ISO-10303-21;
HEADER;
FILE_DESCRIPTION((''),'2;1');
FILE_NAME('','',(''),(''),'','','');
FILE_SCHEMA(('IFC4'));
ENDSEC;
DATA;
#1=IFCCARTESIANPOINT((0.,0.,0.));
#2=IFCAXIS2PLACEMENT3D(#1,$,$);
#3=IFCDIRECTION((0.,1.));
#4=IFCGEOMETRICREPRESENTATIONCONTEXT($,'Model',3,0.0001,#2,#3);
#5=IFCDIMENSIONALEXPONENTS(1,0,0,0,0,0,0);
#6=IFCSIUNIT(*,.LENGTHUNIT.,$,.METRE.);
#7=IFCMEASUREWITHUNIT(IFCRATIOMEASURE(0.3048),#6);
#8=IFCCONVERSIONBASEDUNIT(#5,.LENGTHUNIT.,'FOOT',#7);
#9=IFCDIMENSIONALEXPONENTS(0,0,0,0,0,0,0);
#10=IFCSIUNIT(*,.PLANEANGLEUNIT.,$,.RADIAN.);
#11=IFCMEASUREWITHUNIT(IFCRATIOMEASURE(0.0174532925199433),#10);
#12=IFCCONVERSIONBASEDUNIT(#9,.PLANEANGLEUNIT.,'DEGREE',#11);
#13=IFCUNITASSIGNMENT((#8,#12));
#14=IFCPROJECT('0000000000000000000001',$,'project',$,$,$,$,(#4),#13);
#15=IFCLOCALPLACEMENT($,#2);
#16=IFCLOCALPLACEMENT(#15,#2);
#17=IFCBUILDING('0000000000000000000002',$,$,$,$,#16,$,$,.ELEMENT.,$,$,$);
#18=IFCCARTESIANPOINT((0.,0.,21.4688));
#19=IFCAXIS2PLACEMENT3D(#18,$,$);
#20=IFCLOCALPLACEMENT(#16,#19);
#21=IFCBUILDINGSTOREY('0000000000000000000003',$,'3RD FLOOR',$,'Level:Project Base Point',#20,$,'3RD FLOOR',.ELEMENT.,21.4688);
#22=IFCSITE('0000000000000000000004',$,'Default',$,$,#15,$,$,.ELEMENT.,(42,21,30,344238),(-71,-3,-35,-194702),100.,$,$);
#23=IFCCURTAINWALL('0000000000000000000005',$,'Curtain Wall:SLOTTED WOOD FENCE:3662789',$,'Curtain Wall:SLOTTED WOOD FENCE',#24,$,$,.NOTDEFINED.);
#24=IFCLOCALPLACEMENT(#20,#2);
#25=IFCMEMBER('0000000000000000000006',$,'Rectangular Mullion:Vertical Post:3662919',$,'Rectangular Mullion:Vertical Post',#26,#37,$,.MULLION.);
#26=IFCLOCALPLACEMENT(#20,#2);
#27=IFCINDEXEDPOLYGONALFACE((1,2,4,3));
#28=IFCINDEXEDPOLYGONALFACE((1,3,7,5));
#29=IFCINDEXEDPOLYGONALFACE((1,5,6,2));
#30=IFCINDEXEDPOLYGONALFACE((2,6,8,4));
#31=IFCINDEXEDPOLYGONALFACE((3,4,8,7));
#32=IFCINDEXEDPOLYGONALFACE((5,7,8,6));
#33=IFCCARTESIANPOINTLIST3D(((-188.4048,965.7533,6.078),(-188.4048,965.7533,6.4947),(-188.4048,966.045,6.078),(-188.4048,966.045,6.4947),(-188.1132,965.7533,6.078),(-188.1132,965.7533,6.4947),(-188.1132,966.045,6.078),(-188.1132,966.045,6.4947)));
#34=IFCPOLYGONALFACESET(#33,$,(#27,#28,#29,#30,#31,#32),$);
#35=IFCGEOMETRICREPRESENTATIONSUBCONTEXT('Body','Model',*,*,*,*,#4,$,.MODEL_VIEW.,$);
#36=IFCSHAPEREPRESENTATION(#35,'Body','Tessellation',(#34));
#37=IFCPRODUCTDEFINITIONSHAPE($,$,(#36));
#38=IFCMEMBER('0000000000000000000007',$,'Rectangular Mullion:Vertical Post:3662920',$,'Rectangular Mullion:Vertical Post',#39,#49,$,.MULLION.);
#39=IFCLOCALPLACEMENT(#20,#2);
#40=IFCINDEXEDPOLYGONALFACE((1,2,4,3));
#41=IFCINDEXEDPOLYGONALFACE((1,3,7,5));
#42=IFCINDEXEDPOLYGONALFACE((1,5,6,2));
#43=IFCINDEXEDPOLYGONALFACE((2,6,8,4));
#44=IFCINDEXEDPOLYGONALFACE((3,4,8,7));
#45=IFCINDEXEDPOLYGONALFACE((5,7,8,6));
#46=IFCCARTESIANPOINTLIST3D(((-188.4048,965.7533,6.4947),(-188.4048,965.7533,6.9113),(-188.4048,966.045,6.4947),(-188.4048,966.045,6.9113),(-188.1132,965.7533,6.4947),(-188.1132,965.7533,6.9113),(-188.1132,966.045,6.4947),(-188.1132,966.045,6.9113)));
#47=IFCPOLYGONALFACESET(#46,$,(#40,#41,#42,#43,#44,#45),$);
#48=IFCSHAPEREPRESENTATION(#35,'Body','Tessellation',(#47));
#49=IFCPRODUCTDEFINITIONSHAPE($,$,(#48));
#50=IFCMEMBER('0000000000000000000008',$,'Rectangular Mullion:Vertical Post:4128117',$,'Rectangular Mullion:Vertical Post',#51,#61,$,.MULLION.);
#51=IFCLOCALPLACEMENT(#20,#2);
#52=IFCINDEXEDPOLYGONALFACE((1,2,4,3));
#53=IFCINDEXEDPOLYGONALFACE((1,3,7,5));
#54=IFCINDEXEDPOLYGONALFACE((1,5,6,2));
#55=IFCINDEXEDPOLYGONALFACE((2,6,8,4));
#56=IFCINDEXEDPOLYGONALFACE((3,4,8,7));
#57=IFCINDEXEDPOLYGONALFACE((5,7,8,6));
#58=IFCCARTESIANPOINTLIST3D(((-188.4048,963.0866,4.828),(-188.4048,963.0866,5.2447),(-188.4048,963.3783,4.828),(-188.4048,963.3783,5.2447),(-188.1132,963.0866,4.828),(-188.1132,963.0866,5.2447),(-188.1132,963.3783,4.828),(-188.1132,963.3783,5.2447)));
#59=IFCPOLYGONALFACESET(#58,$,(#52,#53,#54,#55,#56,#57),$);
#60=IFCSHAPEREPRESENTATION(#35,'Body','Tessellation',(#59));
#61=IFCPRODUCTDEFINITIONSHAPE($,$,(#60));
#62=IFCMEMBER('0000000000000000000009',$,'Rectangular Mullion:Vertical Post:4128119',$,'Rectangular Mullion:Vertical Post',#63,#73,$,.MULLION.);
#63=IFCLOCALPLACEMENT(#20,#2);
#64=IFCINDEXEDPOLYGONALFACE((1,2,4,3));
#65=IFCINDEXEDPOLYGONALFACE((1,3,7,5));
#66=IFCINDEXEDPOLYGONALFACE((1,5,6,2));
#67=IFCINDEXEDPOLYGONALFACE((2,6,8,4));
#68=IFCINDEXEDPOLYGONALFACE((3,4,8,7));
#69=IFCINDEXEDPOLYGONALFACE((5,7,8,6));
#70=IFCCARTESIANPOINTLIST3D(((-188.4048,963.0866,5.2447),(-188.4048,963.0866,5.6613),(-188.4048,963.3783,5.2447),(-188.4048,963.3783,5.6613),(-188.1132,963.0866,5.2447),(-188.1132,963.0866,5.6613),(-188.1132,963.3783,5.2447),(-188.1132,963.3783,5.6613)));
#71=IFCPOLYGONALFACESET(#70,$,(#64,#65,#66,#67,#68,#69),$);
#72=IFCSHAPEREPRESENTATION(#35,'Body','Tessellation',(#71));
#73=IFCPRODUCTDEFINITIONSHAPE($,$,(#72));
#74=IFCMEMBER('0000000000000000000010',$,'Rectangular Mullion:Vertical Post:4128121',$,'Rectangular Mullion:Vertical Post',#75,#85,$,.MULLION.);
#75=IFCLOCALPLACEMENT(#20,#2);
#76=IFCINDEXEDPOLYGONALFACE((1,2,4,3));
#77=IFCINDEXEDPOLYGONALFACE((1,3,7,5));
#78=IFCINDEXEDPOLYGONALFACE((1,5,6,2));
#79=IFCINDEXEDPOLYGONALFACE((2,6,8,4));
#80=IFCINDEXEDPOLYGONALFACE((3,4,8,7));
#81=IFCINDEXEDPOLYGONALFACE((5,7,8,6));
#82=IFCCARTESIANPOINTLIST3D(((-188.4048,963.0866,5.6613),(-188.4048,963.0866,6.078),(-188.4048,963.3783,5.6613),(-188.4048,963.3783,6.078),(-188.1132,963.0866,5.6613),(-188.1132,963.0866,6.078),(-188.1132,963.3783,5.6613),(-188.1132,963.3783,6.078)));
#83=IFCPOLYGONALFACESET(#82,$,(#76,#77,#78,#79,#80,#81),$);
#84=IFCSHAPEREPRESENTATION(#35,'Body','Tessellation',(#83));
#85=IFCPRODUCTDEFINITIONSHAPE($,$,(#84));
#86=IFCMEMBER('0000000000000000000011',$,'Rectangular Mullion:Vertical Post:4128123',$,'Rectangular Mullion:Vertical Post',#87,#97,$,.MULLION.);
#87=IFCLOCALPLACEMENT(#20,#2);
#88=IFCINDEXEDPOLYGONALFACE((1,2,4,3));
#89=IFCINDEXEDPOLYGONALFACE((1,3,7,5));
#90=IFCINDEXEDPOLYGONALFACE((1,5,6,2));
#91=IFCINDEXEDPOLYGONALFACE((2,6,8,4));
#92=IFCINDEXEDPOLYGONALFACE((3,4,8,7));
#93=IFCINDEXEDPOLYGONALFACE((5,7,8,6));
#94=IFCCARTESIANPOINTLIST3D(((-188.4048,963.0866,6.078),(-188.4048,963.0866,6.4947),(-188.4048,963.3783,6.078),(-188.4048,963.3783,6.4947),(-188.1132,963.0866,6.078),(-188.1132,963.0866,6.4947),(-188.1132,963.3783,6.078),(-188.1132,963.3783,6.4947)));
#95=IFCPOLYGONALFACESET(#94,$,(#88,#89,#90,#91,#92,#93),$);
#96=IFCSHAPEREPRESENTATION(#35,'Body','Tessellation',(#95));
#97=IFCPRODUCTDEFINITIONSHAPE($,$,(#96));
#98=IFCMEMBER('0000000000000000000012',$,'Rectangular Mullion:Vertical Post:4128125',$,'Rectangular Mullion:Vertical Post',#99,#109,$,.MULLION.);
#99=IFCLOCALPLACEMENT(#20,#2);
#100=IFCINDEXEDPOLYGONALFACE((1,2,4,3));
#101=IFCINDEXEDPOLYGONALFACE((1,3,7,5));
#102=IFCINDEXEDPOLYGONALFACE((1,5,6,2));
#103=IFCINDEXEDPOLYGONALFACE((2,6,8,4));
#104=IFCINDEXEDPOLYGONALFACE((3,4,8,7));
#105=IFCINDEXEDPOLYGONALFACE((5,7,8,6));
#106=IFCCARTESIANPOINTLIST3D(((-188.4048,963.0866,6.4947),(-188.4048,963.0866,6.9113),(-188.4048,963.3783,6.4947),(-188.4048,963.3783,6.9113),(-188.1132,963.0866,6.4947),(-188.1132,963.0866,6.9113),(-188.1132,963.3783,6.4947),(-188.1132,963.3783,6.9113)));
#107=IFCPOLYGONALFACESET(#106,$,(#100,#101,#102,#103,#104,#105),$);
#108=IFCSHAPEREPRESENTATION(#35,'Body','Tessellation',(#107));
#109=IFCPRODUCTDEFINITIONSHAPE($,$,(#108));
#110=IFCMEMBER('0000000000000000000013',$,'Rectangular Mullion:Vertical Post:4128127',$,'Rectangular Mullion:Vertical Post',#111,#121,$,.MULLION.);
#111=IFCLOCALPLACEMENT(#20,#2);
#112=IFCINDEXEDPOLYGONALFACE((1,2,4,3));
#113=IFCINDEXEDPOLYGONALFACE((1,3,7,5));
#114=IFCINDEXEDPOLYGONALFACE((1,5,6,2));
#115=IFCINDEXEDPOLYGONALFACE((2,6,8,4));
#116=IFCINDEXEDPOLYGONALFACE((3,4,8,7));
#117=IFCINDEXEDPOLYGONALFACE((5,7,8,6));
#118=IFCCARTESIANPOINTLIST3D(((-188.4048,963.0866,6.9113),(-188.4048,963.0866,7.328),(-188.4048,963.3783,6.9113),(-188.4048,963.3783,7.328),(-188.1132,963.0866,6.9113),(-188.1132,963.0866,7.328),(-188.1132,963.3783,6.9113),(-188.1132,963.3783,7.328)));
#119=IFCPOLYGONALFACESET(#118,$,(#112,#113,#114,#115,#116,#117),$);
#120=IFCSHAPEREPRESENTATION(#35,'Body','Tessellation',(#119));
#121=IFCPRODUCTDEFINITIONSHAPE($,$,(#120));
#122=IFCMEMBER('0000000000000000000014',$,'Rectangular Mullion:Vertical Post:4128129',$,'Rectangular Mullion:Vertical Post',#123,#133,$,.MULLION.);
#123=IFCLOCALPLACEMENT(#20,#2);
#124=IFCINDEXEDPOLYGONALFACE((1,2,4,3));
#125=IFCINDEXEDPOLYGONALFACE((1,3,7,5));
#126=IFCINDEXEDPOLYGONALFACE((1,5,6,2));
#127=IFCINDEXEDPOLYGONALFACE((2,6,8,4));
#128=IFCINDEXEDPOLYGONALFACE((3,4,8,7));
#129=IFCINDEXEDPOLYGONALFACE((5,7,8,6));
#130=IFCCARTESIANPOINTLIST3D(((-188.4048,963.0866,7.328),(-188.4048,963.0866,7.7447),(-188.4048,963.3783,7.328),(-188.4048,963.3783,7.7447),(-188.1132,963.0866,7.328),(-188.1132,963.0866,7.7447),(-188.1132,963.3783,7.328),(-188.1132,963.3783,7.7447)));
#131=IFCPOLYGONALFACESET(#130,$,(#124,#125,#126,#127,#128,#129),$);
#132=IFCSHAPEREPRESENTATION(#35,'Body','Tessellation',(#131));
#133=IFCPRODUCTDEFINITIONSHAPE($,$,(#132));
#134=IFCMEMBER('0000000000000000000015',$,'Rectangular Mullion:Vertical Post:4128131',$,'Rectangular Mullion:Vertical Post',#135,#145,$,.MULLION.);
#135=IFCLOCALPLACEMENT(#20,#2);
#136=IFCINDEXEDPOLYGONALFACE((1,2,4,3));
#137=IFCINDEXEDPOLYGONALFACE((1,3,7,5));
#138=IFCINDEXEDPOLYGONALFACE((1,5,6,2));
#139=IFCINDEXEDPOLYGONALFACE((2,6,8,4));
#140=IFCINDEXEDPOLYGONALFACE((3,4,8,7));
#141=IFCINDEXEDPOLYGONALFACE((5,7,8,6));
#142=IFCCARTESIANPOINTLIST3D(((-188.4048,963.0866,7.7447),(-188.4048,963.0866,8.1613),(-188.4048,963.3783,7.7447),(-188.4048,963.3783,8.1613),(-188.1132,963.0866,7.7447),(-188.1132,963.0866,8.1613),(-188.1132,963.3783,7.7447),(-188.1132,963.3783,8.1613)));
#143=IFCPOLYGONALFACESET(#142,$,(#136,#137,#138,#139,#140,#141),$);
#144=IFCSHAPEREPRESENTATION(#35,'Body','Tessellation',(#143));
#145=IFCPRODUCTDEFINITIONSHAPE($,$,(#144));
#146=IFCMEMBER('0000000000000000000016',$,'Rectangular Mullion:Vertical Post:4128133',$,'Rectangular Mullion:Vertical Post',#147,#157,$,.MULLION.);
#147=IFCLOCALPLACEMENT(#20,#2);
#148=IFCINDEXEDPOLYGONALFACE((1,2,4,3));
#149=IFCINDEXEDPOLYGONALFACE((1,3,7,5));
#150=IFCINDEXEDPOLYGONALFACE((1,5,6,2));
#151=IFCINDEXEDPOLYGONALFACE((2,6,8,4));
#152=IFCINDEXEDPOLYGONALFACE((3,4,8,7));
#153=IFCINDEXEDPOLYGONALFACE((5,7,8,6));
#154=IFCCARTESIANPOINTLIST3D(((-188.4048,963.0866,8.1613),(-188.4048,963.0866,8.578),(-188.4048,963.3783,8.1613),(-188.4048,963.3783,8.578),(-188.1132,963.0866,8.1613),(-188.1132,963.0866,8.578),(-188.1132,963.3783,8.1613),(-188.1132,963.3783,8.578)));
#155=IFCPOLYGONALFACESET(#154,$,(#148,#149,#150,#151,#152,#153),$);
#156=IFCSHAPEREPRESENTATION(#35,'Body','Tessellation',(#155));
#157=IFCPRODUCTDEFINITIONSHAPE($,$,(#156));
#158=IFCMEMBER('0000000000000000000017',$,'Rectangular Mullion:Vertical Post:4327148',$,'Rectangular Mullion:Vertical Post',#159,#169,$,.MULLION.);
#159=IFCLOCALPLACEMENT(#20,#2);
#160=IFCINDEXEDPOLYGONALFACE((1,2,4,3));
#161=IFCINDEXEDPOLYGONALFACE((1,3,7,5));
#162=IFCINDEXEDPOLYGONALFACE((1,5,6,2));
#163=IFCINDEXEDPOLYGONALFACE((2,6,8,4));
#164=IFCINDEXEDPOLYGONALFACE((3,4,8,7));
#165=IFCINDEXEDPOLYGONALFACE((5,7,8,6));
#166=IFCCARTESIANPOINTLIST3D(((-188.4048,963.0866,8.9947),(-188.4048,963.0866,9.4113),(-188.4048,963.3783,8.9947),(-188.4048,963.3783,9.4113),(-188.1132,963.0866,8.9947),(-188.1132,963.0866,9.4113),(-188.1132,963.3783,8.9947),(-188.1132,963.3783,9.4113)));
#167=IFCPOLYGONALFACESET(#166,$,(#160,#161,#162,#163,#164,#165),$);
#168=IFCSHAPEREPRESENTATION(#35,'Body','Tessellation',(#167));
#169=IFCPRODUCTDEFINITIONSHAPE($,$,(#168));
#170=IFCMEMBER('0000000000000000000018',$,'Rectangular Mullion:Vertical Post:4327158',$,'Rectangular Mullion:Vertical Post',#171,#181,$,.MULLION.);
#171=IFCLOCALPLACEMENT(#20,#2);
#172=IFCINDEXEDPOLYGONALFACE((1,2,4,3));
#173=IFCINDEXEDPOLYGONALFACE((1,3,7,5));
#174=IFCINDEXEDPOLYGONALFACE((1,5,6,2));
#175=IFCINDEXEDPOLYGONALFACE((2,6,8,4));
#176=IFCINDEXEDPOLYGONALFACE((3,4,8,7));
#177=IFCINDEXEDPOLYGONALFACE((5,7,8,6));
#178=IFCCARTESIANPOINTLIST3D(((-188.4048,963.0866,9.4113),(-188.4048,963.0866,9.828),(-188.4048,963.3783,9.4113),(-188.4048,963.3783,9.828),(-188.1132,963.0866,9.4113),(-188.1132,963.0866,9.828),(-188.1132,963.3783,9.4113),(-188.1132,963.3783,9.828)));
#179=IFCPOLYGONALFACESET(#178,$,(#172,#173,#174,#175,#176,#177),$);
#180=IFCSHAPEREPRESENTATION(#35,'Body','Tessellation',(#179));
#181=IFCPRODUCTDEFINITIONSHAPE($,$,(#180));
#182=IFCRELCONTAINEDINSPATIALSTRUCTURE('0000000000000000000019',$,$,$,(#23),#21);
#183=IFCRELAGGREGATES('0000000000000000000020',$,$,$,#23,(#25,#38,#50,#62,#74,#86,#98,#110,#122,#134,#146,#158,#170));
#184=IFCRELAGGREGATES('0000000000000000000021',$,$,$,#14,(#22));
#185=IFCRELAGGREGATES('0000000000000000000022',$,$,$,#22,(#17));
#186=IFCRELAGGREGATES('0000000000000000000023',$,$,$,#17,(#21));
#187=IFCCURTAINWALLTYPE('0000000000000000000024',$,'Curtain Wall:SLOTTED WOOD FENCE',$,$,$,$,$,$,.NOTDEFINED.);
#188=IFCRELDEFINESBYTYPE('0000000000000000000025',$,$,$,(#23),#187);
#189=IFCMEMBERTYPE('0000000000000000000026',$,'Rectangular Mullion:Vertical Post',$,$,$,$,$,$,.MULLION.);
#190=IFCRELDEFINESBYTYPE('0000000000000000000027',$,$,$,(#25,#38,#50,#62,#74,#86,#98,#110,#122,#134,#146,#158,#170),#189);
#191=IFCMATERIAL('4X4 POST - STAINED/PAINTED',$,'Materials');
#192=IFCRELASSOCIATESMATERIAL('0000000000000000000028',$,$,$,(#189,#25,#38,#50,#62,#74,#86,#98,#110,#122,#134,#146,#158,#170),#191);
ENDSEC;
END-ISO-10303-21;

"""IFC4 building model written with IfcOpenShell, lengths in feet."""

from ifc_helpers import new_model, entity, si_unit, converted_unit, direction, frame, origin, origin_2d_with_axis, place, context, subcontext, project, spatial, rectangle, extrude, source, transform, mapped, material, material_profile, profile_set, profile_usage, type_object, type_shapes, element, aggregate, save


model = new_model("IFC4")

# Units and contexts
model_context = context("Model", 3, precision=0.0001, world=origin(), true_north=direction((0.0, 1.0)))
body_context = subcontext(model_context, "Body", "Model", "MODEL_VIEW")
ifc_project = project(units=[converted_unit("LENGTHUNIT", "FOOT", entity("IfcRatioMeasure", 0.3048), si_unit("LENGTHUNIT", "METRE"), dimensions=[1, 0, 0, 0, 0, 0, 0]), converted_unit("PLANEANGLEUNIT", "DEGREE", entity("IfcRatioMeasure", 0.0174532925199433), si_unit("PLANEANGLEUNIT", "RADIAN"), dimensions=[0, 0, 0, 0, 0, 0, 0])], contexts=[model_context])

# Site, building, storey
site_placement = place(None, origin())
site = spatial("IfcSite", under=ifc_project, at=site_placement, Name="Default", CompositionType="ELEMENT", RefLatitude=(42, 21, 30, 344238), RefLongitude=(-71, -3, -35, -194702), RefElevation=100.0)
building_placement = place(site_placement, origin())
building = spatial("IfcBuilding", under=site, at=building_placement, CompositionType="ELEMENT")
storey_placement = place(building_placement, frame((0.0, 0.0, 21.4688)))
storey = spatial("IfcBuildingStorey", under=building, at=storey_placement, Name="3RD FLOOR", ObjectType="Level:Project Base Point", LongName="3RD FLOOR", CompositionType="ELEMENT", Elevation=21.4688)

# Curtain wall, members
curtain_wall_type = type_object("IfcCurtainWallType", Name="Curtain Wall:SLOTTED WOOD FENCE", PredefinedType="NOTDEFINED")
curtain_wall_placement = place(storey_placement, frame((0.0, 0.0, -21.4688)))
curtain_wall = element("IfcCurtainWall", 1, at=curtain_wall_placement, inside=storey, type_object=curtain_wall_type, Name="Curtain Wall:SLOTTED WOOD FENCE:3662789", ObjectType="Curtain Wall:SLOTTED WOOD FENCE", PredefinedType="NOTDEFINED")
ifc_material_1 = material(Name="4X4 POST - STAINED/PAINTED", Category="Materials")
ifc_material_profile = material_profile(ifc_material_1, rectangle(XDim=0.2917, YDim=0.2917, at=origin_2d_with_axis()), Name="Vertical Post")
ifc_profile_set = profile_set([ifc_material_profile], Name="Vertical Post")
member_type_1 = type_object("IfcMemberType", Name="Rectangular Mullion:Vertical Post", PredefinedType="MULLION", material=ifc_profile_set)
shared_shape_1 = source(origin(), body_context, "Body", "SweptSolid", [
    extrude(rectangle(XDim=0.2917, YDim=0.2917, at=origin_2d_with_axis()), frame((0.0, 0.2083, -0.4167), z_axis=(0.0, 0.0, 1.0), x_axis=(0.0, -1.0, 0.0)), (0.0, 0.0, 1.0), 0.4167),
])
type_shapes(member_type_1, [shared_shape_1])
ifc_profile_usage_1 = profile_usage(ifc_profile_set)
member_1_placement = place(storey_placement, frame((-188.0507, 965.8991, 6.078), z_axis=(0.0, 0.0, -1.0), x_axis=(0.0, -1.0, 0.0)))
member_1 = element("IfcMember", 2, at=member_1_placement, type_object=member_type_1, material=ifc_profile_usage_1, Name="Rectangular Mullion:Vertical Post:3662919", ObjectType="Rectangular Mullion:Vertical Post", PredefinedType="MULLION", context=body_context, shape_type="MappedRepresentation", body=[
    mapped(shared_shape_1, transform((0.0, 0.0, 0.0), scale=1.0)),
])
ifc_profile_usage_2 = profile_usage(ifc_profile_set)
member_2_placement = place(storey_placement, frame((-188.0507, 965.8991, 6.4947), z_axis=(0.0, 0.0, -1.0), x_axis=(0.0, -1.0, 0.0)))
member_2 = element("IfcMember", 3, at=member_2_placement, type_object=member_type_1, material=ifc_profile_usage_2, Name="Rectangular Mullion:Vertical Post:3662920", ObjectType="Rectangular Mullion:Vertical Post", PredefinedType="MULLION", context=body_context, shape_type="MappedRepresentation", body=[
    mapped(shared_shape_1, transform((0.0, 0.0, 0.0), scale=1.0)),
])
ifc_profile_usage_3 = profile_usage(ifc_profile_set)
member_3_placement = place(storey_placement, frame((-188.0507, 963.2325, 4.828), z_axis=(0.0, 0.0, -1.0), x_axis=(0.0, -1.0, 0.0)))
member_3 = element("IfcMember", 4, at=member_3_placement, type_object=member_type_1, material=ifc_profile_usage_3, Name="Rectangular Mullion:Vertical Post:4128117", ObjectType="Rectangular Mullion:Vertical Post", PredefinedType="MULLION", context=body_context, shape_type="MappedRepresentation", body=[
    mapped(shared_shape_1, transform((0.0, 0.0, 0.0), scale=1.0)),
])
ifc_profile_usage_4 = profile_usage(ifc_profile_set)
member_4_placement = place(storey_placement, frame((-188.0507, 963.2325, 5.2447), z_axis=(0.0, 0.0, -1.0), x_axis=(0.0, -1.0, 0.0)))
member_4 = element("IfcMember", 5, at=member_4_placement, type_object=member_type_1, material=ifc_profile_usage_4, Name="Rectangular Mullion:Vertical Post:4128119", ObjectType="Rectangular Mullion:Vertical Post", PredefinedType="MULLION", context=body_context, shape_type="MappedRepresentation", body=[
    mapped(shared_shape_1, transform((0.0, 0.0, 0.0), scale=1.0)),
])
ifc_profile_usage_5 = profile_usage(ifc_profile_set)
member_5_placement = place(storey_placement, frame((-188.0507, 963.2325, 5.6613), z_axis=(0.0, 0.0, -1.0), x_axis=(0.0, -1.0, 0.0)))
member_5 = element("IfcMember", 6, at=member_5_placement, type_object=member_type_1, material=ifc_profile_usage_5, Name="Rectangular Mullion:Vertical Post:4128121", ObjectType="Rectangular Mullion:Vertical Post", PredefinedType="MULLION", context=body_context, shape_type="MappedRepresentation", body=[
    mapped(shared_shape_1, transform((0.0, 0.0, 0.0), scale=1.0)),
])
ifc_profile_usage_6 = profile_usage(ifc_profile_set)
member_6_placement = place(storey_placement, frame((-188.0507, 963.2325, 6.078), z_axis=(0.0, 0.0, -1.0), x_axis=(0.0, -1.0, 0.0)))
member_6 = element("IfcMember", 7, at=member_6_placement, type_object=member_type_1, material=ifc_profile_usage_6, Name="Rectangular Mullion:Vertical Post:4128123", ObjectType="Rectangular Mullion:Vertical Post", PredefinedType="MULLION", context=body_context, shape_type="MappedRepresentation", body=[
    mapped(shared_shape_1, transform((0.0, 0.0, 0.0), scale=1.0)),
])
ifc_profile_usage_7 = profile_usage(ifc_profile_set)
member_7_placement = place(storey_placement, frame((-188.0507, 963.2325, 6.4947), z_axis=(0.0, 0.0, -1.0), x_axis=(0.0, -1.0, 0.0)))
member_7 = element("IfcMember", 8, at=member_7_placement, type_object=member_type_1, material=ifc_profile_usage_7, Name="Rectangular Mullion:Vertical Post:4128125", ObjectType="Rectangular Mullion:Vertical Post", PredefinedType="MULLION", context=body_context, shape_type="MappedRepresentation", body=[
    mapped(shared_shape_1, transform((0.0, 0.0, 0.0), scale=1.0)),
])
ifc_profile_usage_8 = profile_usage(ifc_profile_set)
member_8_placement = place(storey_placement, frame((-188.0507, 963.2325, 6.9113), z_axis=(0.0, 0.0, -1.0), x_axis=(0.0, -1.0, 0.0)))
member_8 = element("IfcMember", 9, at=member_8_placement, type_object=member_type_1, material=ifc_profile_usage_8, Name="Rectangular Mullion:Vertical Post:4128127", ObjectType="Rectangular Mullion:Vertical Post", PredefinedType="MULLION", context=body_context, shape_type="MappedRepresentation", body=[
    mapped(shared_shape_1, transform((0.0, 0.0, 0.0), scale=1.0)),
])
ifc_profile_usage_9 = profile_usage(ifc_profile_set)
member_9_placement = place(storey_placement, frame((-188.0507, 963.2325, 7.328), z_axis=(0.0, 0.0, -1.0), x_axis=(0.0, -1.0, 0.0)))
member_9 = element("IfcMember", 10, at=member_9_placement, type_object=member_type_1, material=ifc_profile_usage_9, Name="Rectangular Mullion:Vertical Post:4128129", ObjectType="Rectangular Mullion:Vertical Post", PredefinedType="MULLION", context=body_context, shape_type="MappedRepresentation", body=[
    mapped(shared_shape_1, transform((0.0, 0.0, 0.0), scale=1.0)),
])
ifc_profile_usage_10 = profile_usage(ifc_profile_set)
member_10_placement = place(storey_placement, frame((-188.0507, 963.2325, 7.7447), z_axis=(0.0, 0.0, -1.0), x_axis=(0.0, -1.0, 0.0)))
member_10 = element("IfcMember", 11, at=member_10_placement, type_object=member_type_1, material=ifc_profile_usage_10, Name="Rectangular Mullion:Vertical Post:4128131", ObjectType="Rectangular Mullion:Vertical Post", PredefinedType="MULLION", context=body_context, shape_type="MappedRepresentation", body=[
    mapped(shared_shape_1, transform((0.0, 0.0, 0.0), scale=1.0)),
])
ifc_profile_usage_11 = profile_usage(ifc_profile_set)
member_11_placement = place(storey_placement, frame((-188.0507, 963.2325, 8.1613), z_axis=(0.0, 0.0, -1.0), x_axis=(0.0, -1.0, 0.0)))
member_11 = element("IfcMember", 12, at=member_11_placement, type_object=member_type_1, material=ifc_profile_usage_11, Name="Rectangular Mullion:Vertical Post:4128133", ObjectType="Rectangular Mullion:Vertical Post", PredefinedType="MULLION", context=body_context, shape_type="MappedRepresentation", body=[
    mapped(shared_shape_1, transform((0.0, 0.0, 0.0), scale=1.0)),
])
ifc_profile_usage_12 = profile_usage(ifc_profile_set)
member_12_placement = place(storey_placement, frame((-188.0507, 963.2325, 8.9947), z_axis=(0.0, 0.0, -1.0), x_axis=(0.0, -1.0, 0.0)))
member_12 = element("IfcMember", 13, at=member_12_placement, type_object=member_type_1, material=ifc_profile_usage_12, Name="Rectangular Mullion:Vertical Post:4327148", ObjectType="Rectangular Mullion:Vertical Post", PredefinedType="MULLION", context=body_context, shape_type="MappedRepresentation", body=[
    mapped(shared_shape_1, transform((0.0, 0.0, 0.0), scale=1.0)),
])
ifc_profile_usage_13 = profile_usage(ifc_profile_set)
member_13_placement = place(storey_placement, frame((-188.0507, 963.2325, 9.4113), z_axis=(0.0, 0.0, -1.0), x_axis=(0.0, -1.0, 0.0)))
member_13 = element("IfcMember", 14, at=member_13_placement, type_object=member_type_1, material=ifc_profile_usage_13, Name="Rectangular Mullion:Vertical Post:4327158", ObjectType="Rectangular Mullion:Vertical Post", PredefinedType="MULLION", context=body_context, shape_type="MappedRepresentation", body=[
    mapped(shared_shape_1, transform((0.0, 0.0, 0.0), scale=1.0)),
])
aggregate(curtain_wall, [member_1, member_2, member_3, member_4, member_5, member_6, member_7, member_8, member_9, member_10, member_11, member_12, member_13])

save(model, "model.ifc")
